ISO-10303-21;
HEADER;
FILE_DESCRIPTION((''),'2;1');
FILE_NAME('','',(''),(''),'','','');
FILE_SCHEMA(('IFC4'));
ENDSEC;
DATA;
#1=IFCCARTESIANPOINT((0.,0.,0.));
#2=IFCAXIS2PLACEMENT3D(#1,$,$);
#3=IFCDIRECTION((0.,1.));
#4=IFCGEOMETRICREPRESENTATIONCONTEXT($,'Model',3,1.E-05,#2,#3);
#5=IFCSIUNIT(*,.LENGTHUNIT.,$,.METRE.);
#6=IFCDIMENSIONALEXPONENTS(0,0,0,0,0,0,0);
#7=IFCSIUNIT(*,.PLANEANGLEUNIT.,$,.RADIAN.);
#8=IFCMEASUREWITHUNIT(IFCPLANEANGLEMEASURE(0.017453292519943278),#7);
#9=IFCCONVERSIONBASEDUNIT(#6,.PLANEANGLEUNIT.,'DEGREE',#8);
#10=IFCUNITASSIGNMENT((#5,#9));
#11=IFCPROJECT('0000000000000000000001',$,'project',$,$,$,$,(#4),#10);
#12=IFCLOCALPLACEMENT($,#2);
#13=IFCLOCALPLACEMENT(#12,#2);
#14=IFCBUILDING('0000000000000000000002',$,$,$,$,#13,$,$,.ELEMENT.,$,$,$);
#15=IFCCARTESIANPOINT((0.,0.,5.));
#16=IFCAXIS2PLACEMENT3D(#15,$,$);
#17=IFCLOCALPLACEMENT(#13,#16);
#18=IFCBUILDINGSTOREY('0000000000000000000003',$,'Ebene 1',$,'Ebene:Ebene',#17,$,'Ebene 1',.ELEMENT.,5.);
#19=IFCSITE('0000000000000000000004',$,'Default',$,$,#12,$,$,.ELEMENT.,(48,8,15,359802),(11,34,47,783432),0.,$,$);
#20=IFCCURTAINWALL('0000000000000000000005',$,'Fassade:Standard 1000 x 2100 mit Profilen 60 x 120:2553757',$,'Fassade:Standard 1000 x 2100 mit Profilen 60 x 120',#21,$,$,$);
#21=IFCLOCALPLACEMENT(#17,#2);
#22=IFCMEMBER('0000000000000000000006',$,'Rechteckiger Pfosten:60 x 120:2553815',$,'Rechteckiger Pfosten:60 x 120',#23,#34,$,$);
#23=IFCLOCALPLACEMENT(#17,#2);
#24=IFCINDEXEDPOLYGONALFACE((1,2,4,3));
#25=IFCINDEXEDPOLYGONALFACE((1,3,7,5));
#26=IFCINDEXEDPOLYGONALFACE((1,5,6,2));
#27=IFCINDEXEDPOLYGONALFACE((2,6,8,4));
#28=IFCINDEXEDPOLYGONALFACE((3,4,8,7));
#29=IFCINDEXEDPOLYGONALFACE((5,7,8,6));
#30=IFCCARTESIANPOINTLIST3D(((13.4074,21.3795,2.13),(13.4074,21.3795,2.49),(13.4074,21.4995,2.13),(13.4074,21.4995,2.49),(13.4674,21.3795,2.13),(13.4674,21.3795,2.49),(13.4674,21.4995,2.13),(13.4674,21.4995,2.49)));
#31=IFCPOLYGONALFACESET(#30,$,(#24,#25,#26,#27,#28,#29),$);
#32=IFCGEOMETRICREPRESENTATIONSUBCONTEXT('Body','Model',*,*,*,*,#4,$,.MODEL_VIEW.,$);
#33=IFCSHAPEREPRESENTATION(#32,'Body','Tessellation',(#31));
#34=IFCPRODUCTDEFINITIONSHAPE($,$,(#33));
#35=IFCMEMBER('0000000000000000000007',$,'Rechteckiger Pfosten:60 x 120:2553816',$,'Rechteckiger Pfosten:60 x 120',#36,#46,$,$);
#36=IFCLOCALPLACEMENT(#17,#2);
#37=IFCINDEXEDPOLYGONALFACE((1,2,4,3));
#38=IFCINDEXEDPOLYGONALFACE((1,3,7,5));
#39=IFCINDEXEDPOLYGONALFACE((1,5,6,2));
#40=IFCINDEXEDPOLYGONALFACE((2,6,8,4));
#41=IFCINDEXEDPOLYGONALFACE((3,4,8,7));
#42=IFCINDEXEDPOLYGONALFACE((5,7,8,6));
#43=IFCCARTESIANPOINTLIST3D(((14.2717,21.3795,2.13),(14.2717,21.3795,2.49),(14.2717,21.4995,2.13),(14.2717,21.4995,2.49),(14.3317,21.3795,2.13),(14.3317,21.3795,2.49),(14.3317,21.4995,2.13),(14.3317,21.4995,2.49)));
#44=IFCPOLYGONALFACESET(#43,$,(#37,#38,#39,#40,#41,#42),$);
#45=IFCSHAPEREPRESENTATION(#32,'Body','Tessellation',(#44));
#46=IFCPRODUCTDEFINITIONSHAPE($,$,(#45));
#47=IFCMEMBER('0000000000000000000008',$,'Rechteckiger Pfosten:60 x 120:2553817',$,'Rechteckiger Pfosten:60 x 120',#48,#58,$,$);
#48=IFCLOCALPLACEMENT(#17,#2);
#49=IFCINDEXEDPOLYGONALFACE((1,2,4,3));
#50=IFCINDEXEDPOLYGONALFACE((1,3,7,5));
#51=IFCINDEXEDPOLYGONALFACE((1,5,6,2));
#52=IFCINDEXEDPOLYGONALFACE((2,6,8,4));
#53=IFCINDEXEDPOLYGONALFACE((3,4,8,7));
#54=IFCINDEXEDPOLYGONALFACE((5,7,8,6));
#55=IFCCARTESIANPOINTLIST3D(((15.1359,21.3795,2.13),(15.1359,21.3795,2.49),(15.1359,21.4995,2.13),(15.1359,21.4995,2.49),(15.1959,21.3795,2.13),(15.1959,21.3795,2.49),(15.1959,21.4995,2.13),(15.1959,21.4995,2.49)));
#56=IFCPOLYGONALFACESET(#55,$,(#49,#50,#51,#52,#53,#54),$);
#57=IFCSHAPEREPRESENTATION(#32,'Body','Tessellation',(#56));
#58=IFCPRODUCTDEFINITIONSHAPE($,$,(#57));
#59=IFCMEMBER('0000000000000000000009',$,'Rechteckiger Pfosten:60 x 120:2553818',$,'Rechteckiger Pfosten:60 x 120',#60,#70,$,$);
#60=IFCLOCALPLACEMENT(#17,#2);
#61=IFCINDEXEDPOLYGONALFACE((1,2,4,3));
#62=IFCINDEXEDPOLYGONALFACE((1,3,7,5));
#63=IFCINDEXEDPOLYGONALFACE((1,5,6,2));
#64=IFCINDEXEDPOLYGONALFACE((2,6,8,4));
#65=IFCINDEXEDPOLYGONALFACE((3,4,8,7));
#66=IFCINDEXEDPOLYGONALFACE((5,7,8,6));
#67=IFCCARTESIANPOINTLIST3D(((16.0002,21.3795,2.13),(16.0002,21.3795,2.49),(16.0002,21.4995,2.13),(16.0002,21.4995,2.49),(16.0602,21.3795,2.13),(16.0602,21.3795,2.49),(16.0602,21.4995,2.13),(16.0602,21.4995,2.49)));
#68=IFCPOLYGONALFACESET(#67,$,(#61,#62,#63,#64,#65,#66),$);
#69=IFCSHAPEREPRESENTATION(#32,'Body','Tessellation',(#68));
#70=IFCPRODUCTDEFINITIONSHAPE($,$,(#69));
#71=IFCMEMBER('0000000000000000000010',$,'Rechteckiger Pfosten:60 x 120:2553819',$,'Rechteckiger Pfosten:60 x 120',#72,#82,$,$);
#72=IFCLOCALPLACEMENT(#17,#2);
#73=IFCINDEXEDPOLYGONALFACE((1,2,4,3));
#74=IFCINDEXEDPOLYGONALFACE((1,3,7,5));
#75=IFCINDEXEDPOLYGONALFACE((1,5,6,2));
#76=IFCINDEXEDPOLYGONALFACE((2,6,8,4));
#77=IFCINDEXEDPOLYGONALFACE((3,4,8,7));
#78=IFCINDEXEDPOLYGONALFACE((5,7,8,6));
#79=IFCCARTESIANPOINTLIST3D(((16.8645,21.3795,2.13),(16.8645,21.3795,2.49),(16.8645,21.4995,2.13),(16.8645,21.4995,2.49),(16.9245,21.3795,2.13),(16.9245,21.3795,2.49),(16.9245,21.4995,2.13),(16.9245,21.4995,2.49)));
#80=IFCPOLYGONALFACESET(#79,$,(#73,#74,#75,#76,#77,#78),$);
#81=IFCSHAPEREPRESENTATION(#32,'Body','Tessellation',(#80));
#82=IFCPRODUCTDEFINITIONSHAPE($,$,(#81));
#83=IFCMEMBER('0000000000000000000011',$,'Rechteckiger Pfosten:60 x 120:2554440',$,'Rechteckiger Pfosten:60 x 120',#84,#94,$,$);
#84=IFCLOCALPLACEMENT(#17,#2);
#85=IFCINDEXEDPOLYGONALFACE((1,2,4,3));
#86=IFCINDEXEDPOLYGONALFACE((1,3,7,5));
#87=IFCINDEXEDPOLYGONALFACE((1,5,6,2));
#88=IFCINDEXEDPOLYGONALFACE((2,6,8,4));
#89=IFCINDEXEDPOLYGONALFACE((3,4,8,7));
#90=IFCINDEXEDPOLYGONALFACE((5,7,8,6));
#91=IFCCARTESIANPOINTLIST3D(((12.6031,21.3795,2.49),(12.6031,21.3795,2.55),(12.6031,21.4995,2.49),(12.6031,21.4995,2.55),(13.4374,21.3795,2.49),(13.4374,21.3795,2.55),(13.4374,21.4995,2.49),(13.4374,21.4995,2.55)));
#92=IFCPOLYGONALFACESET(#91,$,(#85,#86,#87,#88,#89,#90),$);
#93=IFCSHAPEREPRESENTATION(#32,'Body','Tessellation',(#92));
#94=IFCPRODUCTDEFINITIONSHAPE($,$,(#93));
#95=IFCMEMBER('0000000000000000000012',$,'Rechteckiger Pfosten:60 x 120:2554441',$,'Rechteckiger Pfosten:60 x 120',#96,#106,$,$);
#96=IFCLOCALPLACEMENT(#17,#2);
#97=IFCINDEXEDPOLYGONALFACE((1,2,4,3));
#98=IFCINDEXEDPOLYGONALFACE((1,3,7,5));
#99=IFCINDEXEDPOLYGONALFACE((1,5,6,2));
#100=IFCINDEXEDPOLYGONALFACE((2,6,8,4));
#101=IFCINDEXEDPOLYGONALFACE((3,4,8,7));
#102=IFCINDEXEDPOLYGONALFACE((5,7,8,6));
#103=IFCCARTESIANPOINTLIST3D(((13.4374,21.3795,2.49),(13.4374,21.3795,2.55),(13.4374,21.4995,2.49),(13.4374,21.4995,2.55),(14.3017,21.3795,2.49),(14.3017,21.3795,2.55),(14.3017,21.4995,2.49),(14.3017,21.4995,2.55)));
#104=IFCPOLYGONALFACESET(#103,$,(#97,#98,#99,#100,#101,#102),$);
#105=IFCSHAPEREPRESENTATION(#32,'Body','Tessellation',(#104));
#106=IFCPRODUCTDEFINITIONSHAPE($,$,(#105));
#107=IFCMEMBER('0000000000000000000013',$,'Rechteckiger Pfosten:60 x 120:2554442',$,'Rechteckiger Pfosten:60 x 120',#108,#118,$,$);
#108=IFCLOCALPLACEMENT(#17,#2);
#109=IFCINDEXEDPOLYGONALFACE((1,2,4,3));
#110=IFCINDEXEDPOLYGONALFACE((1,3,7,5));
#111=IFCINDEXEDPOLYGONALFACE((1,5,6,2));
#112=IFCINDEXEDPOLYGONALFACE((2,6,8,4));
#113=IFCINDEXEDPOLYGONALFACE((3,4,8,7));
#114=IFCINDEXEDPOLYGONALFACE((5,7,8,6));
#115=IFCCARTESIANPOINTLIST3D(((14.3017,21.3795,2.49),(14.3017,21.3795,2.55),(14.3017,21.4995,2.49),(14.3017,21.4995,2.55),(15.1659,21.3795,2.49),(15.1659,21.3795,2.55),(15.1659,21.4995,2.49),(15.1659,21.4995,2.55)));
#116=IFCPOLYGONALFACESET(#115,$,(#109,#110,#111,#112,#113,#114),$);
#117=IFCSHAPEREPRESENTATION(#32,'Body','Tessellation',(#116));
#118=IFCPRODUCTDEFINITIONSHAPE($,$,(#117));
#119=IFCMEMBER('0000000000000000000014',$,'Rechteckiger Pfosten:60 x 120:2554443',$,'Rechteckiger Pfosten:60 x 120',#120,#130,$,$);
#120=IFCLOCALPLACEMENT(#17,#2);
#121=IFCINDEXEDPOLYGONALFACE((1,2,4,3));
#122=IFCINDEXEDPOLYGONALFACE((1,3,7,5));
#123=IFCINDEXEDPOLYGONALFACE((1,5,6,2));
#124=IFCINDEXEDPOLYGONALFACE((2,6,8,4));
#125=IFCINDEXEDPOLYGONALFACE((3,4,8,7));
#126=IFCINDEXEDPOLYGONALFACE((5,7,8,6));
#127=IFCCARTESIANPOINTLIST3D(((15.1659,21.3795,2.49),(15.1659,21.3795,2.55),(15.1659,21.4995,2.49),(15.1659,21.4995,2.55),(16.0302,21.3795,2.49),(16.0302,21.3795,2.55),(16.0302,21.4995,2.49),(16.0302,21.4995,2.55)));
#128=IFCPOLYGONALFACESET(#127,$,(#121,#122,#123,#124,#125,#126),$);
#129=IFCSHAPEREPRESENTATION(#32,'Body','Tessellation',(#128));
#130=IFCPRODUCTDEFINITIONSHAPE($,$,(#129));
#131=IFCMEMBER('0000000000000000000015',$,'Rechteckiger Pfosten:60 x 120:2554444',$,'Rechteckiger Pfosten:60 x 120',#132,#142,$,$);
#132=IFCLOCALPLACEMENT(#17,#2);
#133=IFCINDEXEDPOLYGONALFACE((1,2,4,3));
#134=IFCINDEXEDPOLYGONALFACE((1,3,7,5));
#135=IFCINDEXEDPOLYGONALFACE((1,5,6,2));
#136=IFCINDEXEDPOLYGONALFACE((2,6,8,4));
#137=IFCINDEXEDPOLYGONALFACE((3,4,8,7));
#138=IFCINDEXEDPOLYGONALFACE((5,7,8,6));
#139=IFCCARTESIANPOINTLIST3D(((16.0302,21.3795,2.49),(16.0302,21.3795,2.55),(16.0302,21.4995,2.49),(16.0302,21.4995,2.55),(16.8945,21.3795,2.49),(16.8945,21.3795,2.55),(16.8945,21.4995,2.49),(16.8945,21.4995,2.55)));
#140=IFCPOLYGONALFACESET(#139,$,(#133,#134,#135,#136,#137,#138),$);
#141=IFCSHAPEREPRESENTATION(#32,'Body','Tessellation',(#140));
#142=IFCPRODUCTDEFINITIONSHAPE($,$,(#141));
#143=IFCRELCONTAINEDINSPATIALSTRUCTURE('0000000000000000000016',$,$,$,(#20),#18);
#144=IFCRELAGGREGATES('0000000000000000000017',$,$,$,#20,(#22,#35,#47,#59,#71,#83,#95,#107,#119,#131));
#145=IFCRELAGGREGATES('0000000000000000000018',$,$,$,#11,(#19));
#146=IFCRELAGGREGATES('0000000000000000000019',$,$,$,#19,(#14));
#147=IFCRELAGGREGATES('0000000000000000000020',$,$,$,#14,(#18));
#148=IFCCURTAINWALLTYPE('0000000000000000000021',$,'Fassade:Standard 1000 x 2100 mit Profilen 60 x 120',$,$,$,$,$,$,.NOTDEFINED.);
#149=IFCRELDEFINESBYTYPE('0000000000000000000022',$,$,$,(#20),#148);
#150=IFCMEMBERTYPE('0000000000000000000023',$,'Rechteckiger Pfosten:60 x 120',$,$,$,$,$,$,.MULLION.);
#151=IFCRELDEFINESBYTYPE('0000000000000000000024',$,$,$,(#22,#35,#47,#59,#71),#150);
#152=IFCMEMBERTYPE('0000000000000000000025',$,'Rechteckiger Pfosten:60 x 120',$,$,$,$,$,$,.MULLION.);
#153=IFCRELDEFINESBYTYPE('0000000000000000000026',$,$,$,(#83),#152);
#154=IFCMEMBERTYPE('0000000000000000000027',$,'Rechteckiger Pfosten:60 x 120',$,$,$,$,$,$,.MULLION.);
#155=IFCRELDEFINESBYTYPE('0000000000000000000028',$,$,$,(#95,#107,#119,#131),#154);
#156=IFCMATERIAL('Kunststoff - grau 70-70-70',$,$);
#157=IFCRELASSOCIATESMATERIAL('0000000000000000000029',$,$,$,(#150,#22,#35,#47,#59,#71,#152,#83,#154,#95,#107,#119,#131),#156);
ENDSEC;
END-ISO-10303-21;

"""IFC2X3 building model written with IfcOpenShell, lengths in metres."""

from ifc_helpers import new_model, entity, si_unit, converted_unit, direction, frame, frame_2d, origin, origin_2d_with_axis, place, context, subcontext, project, spatial, rectangle, extrude, source, transform, mapped, material, type_object, type_shapes, element, aggregate, save


model = new_model("IFC2X3")

# Units and contexts
model_context = context("Model", 3, precision=1e-05, world=origin(), true_north=direction((0.0, 1.0)))
body_context = subcontext(model_context, "Body", "Model", "MODEL_VIEW")
ifc_project = project(units=[si_unit("LENGTHUNIT", "METRE"), converted_unit("PLANEANGLEUNIT", "DEGREE", entity("IfcPlaneAngleMeasure", 0.017453292519943278), si_unit("PLANEANGLEUNIT", "RADIAN"), dimensions=[0, 0, 0, 0, 0, 0, 0])], contexts=[model_context])

# Site, building, storey
site_placement = place(None, origin())
site = spatial("IfcSite", under=ifc_project, at=site_placement, Name="Default", CompositionType="ELEMENT", RefLatitude=(48, 8, 15, 359802), RefLongitude=(11, 34, 47, 783432), RefElevation=0.0)
building_placement = place(site_placement, origin())
building = spatial("IfcBuilding", under=site, at=building_placement, CompositionType="ELEMENT")
storey_placement = place(building_placement, frame((0.0, 0.0, 5.0)))
storey = spatial("IfcBuildingStorey", under=building, at=storey_placement, Name="Ebene 1", ObjectType="Ebene:Ebene", LongName="Ebene 1", CompositionType="ELEMENT", Elevation=5.0)

# Curtain wall, members
curtain_wall_type = type_object("IfcCurtainWallType", Name="Fassade:Standard 1000 x 2100 mit Profilen 60 x 120", PredefinedType="NOTDEFINED")
curtain_wall_placement = place(storey_placement, frame((0.0, 0.0, -5.0)))
curtain_wall = element("IfcCurtainWall", 1, at=curtain_wall_placement, inside=storey, type_object=curtain_wall_type, Name="Fassade:Standard 1000 x 2100 mit Profilen 60 x 120:2553757", ObjectType="Fassade:Standard 1000 x 2100 mit Profilen 60 x 120")
ifc_material_1 = material(Name="Kunststoff - grau 70-70-70")
member_type_1 = type_object("IfcMemberType", Name="Rechteckiger Pfosten:60 x 120", PredefinedType="MULLION", material=ifc_material_1)
shared_shape_1 = source(origin(), body_context, "Body", "SweptSolid", [
    extrude(rectangle(XDim=0.06, YDim=0.12, at=frame_2d((0.0, 0.0), x_axis=(1.0, 0.0))), frame((0.0, 0.0, -0.36), z_axis=(0.0, 0.0, 1.0), x_axis=(-1.0, 0.0, 0.0)), (0.0, 0.0, 1.0), 0.36),
])
type_shapes(member_type_1, [shared_shape_1])
member_1_placement = place(curtain_wall_placement, frame((13.4374, 21.4395, 7.13), z_axis=(0.0, 0.0, -1.0), x_axis=(1.0, 0.0, 0.0)))
member_1 = element("IfcMember", 2, at=member_1_placement, type_object=member_type_1, material=ifc_material_1, Name="Rechteckiger Pfosten:60 x 120:2553815", ObjectType="Rechteckiger Pfosten:60 x 120", context=body_context, shape_type="MappedRepresentation", body=[
    mapped(shared_shape_1, transform((0.0, 0.0, 0.0), scale=1.0)),
])
member_2_placement = place(curtain_wall_placement, frame((14.3017, 21.4395, 7.13), z_axis=(0.0, 0.0, -1.0), x_axis=(1.0, 0.0, 0.0)))
member_2 = element("IfcMember", 3, at=member_2_placement, type_object=member_type_1, material=ifc_material_1, Name="Rechteckiger Pfosten:60 x 120:2553816", ObjectType="Rechteckiger Pfosten:60 x 120", context=body_context, shape_type="MappedRepresentation", body=[
    mapped(shared_shape_1, transform((0.0, 0.0, 0.0), scale=1.0)),
])
member_3_placement = place(curtain_wall_placement, frame((15.1659, 21.4395, 7.13), z_axis=(0.0, 0.0, -1.0), x_axis=(1.0, 0.0, 0.0)))
member_3 = element("IfcMember", 4, at=member_3_placement, type_object=member_type_1, material=ifc_material_1, Name="Rechteckiger Pfosten:60 x 120:2553817", ObjectType="Rechteckiger Pfosten:60 x 120", context=body_context, shape_type="MappedRepresentation", body=[
    mapped(shared_shape_1, transform((0.0, 0.0, 0.0), scale=1.0)),
])
member_4_placement = place(curtain_wall_placement, frame((16.0302, 21.4395, 7.13), z_axis=(0.0, 0.0, -1.0), x_axis=(1.0, 0.0, 0.0)))
member_4 = element("IfcMember", 5, at=member_4_placement, type_object=member_type_1, material=ifc_material_1, Name="Rechteckiger Pfosten:60 x 120:2553818", ObjectType="Rechteckiger Pfosten:60 x 120", context=body_context, shape_type="MappedRepresentation", body=[
    mapped(shared_shape_1, transform((0.0, 0.0, 0.0), scale=1.0)),
])
member_5_placement = place(curtain_wall_placement, frame((16.8945, 21.4395, 7.13), z_axis=(0.0, 0.0, -1.0), x_axis=(1.0, 0.0, 0.0)))
member_5 = element("IfcMember", 6, at=member_5_placement, type_object=member_type_1, material=ifc_material_1, Name="Rechteckiger Pfosten:60 x 120:2553819", ObjectType="Rechteckiger Pfosten:60 x 120", context=body_context, shape_type="MappedRepresentation", body=[
    mapped(shared_shape_1, transform((0.0, 0.0, 0.0), scale=1.0)),
])
member_type_2 = type_object("IfcMemberType", Name="Rechteckiger Pfosten:60 x 120", PredefinedType="MULLION", material=ifc_material_1)
shared_shape_2 = source(origin(), body_context, "Body", "SweptSolid", [
    extrude(rectangle(XDim=0.06, YDim=0.12, at=origin_2d_with_axis()), frame((-0.03, 0.0, -0.8343), z_axis=(0.0, 0.0, 1.0), x_axis=(-1.0, 0.0, 0.0)), (0.0, 0.0, 1.0), 0.8343),
])
type_shapes(member_type_2, [shared_shape_2])
member_6_placement = place(curtain_wall_placement, frame((13.4374, 21.4395, 7.55), z_axis=(1.0, 0.0, 0.0), x_axis=(0.0, 0.0, 1.0)))
member_6 = element("IfcMember", 7, at=member_6_placement, type_object=member_type_2, material=ifc_material_1, Name="Rechteckiger Pfosten:60 x 120:2554440", ObjectType="Rechteckiger Pfosten:60 x 120", context=body_context, shape_type="MappedRepresentation", body=[
    mapped(shared_shape_2, transform((0.0, 0.0, 0.0), scale=1.0)),
])
member_type_3 = type_object("IfcMemberType", Name="Rechteckiger Pfosten:60 x 120", PredefinedType="MULLION", material=ifc_material_1)
shared_shape_3 = source(origin(), body_context, "Body", "SweptSolid", [
    extrude(rectangle(XDim=0.06, YDim=0.12, at=origin_2d_with_axis()), frame((-0.03, 0.0, -0.8643), z_axis=(0.0, 0.0, 1.0), x_axis=(-1.0, 0.0, 0.0)), (0.0, 0.0, 1.0), 0.8643),
])
type_shapes(member_type_3, [shared_shape_3])
member_7_placement = place(curtain_wall_placement, frame((14.3017, 21.4395, 7.55), z_axis=(1.0, 0.0, 0.0), x_axis=(0.0, 0.0, 1.0)))
member_7 = element("IfcMember", 8, at=member_7_placement, type_object=member_type_3, material=ifc_material_1, Name="Rechteckiger Pfosten:60 x 120:2554441", ObjectType="Rechteckiger Pfosten:60 x 120", context=body_context, shape_type="MappedRepresentation", body=[
    mapped(shared_shape_3, transform((0.0, 0.0, 0.0), scale=1.0)),
])
member_8_placement = place(curtain_wall_placement, frame((15.1659, 21.4395, 7.55), z_axis=(1.0, 0.0, 0.0), x_axis=(0.0, 0.0, 1.0)))
member_8 = element("IfcMember", 9, at=member_8_placement, type_object=member_type_3, material=ifc_material_1, Name="Rechteckiger Pfosten:60 x 120:2554442", ObjectType="Rechteckiger Pfosten:60 x 120", context=body_context, shape_type="MappedRepresentation", body=[
    mapped(shared_shape_3, transform((0.0, 0.0, 0.0), scale=1.0)),
])
member_9_placement = place(curtain_wall_placement, frame((16.0302, 21.4395, 7.55), z_axis=(1.0, 0.0, 0.0), x_axis=(0.0, 0.0, 1.0)))
member_9 = element("IfcMember", 10, at=member_9_placement, type_object=member_type_3, material=ifc_material_1, Name="Rechteckiger Pfosten:60 x 120:2554443", ObjectType="Rechteckiger Pfosten:60 x 120", context=body_context, shape_type="MappedRepresentation", body=[
    mapped(shared_shape_3, transform((0.0, 0.0, 0.0), scale=1.0)),
])
member_10_placement = place(curtain_wall_placement, frame((16.8945, 21.4395, 7.55), z_axis=(1.0, 0.0, 0.0), x_axis=(0.0, 0.0, 1.0)))
member_10 = element("IfcMember", 11, at=member_10_placement, type_object=member_type_3, material=ifc_material_1, Name="Rechteckiger Pfosten:60 x 120:2554444", ObjectType="Rechteckiger Pfosten:60 x 120", context=body_context, shape_type="MappedRepresentation", body=[
    mapped(shared_shape_3, transform((0.0, 0.0, 0.0), scale=1.0)),
])
aggregate(curtain_wall, [member_1, member_2, member_3, member_4, member_5, member_6, member_7, member_8, member_9, member_10])

save(model, "model.ifc")
